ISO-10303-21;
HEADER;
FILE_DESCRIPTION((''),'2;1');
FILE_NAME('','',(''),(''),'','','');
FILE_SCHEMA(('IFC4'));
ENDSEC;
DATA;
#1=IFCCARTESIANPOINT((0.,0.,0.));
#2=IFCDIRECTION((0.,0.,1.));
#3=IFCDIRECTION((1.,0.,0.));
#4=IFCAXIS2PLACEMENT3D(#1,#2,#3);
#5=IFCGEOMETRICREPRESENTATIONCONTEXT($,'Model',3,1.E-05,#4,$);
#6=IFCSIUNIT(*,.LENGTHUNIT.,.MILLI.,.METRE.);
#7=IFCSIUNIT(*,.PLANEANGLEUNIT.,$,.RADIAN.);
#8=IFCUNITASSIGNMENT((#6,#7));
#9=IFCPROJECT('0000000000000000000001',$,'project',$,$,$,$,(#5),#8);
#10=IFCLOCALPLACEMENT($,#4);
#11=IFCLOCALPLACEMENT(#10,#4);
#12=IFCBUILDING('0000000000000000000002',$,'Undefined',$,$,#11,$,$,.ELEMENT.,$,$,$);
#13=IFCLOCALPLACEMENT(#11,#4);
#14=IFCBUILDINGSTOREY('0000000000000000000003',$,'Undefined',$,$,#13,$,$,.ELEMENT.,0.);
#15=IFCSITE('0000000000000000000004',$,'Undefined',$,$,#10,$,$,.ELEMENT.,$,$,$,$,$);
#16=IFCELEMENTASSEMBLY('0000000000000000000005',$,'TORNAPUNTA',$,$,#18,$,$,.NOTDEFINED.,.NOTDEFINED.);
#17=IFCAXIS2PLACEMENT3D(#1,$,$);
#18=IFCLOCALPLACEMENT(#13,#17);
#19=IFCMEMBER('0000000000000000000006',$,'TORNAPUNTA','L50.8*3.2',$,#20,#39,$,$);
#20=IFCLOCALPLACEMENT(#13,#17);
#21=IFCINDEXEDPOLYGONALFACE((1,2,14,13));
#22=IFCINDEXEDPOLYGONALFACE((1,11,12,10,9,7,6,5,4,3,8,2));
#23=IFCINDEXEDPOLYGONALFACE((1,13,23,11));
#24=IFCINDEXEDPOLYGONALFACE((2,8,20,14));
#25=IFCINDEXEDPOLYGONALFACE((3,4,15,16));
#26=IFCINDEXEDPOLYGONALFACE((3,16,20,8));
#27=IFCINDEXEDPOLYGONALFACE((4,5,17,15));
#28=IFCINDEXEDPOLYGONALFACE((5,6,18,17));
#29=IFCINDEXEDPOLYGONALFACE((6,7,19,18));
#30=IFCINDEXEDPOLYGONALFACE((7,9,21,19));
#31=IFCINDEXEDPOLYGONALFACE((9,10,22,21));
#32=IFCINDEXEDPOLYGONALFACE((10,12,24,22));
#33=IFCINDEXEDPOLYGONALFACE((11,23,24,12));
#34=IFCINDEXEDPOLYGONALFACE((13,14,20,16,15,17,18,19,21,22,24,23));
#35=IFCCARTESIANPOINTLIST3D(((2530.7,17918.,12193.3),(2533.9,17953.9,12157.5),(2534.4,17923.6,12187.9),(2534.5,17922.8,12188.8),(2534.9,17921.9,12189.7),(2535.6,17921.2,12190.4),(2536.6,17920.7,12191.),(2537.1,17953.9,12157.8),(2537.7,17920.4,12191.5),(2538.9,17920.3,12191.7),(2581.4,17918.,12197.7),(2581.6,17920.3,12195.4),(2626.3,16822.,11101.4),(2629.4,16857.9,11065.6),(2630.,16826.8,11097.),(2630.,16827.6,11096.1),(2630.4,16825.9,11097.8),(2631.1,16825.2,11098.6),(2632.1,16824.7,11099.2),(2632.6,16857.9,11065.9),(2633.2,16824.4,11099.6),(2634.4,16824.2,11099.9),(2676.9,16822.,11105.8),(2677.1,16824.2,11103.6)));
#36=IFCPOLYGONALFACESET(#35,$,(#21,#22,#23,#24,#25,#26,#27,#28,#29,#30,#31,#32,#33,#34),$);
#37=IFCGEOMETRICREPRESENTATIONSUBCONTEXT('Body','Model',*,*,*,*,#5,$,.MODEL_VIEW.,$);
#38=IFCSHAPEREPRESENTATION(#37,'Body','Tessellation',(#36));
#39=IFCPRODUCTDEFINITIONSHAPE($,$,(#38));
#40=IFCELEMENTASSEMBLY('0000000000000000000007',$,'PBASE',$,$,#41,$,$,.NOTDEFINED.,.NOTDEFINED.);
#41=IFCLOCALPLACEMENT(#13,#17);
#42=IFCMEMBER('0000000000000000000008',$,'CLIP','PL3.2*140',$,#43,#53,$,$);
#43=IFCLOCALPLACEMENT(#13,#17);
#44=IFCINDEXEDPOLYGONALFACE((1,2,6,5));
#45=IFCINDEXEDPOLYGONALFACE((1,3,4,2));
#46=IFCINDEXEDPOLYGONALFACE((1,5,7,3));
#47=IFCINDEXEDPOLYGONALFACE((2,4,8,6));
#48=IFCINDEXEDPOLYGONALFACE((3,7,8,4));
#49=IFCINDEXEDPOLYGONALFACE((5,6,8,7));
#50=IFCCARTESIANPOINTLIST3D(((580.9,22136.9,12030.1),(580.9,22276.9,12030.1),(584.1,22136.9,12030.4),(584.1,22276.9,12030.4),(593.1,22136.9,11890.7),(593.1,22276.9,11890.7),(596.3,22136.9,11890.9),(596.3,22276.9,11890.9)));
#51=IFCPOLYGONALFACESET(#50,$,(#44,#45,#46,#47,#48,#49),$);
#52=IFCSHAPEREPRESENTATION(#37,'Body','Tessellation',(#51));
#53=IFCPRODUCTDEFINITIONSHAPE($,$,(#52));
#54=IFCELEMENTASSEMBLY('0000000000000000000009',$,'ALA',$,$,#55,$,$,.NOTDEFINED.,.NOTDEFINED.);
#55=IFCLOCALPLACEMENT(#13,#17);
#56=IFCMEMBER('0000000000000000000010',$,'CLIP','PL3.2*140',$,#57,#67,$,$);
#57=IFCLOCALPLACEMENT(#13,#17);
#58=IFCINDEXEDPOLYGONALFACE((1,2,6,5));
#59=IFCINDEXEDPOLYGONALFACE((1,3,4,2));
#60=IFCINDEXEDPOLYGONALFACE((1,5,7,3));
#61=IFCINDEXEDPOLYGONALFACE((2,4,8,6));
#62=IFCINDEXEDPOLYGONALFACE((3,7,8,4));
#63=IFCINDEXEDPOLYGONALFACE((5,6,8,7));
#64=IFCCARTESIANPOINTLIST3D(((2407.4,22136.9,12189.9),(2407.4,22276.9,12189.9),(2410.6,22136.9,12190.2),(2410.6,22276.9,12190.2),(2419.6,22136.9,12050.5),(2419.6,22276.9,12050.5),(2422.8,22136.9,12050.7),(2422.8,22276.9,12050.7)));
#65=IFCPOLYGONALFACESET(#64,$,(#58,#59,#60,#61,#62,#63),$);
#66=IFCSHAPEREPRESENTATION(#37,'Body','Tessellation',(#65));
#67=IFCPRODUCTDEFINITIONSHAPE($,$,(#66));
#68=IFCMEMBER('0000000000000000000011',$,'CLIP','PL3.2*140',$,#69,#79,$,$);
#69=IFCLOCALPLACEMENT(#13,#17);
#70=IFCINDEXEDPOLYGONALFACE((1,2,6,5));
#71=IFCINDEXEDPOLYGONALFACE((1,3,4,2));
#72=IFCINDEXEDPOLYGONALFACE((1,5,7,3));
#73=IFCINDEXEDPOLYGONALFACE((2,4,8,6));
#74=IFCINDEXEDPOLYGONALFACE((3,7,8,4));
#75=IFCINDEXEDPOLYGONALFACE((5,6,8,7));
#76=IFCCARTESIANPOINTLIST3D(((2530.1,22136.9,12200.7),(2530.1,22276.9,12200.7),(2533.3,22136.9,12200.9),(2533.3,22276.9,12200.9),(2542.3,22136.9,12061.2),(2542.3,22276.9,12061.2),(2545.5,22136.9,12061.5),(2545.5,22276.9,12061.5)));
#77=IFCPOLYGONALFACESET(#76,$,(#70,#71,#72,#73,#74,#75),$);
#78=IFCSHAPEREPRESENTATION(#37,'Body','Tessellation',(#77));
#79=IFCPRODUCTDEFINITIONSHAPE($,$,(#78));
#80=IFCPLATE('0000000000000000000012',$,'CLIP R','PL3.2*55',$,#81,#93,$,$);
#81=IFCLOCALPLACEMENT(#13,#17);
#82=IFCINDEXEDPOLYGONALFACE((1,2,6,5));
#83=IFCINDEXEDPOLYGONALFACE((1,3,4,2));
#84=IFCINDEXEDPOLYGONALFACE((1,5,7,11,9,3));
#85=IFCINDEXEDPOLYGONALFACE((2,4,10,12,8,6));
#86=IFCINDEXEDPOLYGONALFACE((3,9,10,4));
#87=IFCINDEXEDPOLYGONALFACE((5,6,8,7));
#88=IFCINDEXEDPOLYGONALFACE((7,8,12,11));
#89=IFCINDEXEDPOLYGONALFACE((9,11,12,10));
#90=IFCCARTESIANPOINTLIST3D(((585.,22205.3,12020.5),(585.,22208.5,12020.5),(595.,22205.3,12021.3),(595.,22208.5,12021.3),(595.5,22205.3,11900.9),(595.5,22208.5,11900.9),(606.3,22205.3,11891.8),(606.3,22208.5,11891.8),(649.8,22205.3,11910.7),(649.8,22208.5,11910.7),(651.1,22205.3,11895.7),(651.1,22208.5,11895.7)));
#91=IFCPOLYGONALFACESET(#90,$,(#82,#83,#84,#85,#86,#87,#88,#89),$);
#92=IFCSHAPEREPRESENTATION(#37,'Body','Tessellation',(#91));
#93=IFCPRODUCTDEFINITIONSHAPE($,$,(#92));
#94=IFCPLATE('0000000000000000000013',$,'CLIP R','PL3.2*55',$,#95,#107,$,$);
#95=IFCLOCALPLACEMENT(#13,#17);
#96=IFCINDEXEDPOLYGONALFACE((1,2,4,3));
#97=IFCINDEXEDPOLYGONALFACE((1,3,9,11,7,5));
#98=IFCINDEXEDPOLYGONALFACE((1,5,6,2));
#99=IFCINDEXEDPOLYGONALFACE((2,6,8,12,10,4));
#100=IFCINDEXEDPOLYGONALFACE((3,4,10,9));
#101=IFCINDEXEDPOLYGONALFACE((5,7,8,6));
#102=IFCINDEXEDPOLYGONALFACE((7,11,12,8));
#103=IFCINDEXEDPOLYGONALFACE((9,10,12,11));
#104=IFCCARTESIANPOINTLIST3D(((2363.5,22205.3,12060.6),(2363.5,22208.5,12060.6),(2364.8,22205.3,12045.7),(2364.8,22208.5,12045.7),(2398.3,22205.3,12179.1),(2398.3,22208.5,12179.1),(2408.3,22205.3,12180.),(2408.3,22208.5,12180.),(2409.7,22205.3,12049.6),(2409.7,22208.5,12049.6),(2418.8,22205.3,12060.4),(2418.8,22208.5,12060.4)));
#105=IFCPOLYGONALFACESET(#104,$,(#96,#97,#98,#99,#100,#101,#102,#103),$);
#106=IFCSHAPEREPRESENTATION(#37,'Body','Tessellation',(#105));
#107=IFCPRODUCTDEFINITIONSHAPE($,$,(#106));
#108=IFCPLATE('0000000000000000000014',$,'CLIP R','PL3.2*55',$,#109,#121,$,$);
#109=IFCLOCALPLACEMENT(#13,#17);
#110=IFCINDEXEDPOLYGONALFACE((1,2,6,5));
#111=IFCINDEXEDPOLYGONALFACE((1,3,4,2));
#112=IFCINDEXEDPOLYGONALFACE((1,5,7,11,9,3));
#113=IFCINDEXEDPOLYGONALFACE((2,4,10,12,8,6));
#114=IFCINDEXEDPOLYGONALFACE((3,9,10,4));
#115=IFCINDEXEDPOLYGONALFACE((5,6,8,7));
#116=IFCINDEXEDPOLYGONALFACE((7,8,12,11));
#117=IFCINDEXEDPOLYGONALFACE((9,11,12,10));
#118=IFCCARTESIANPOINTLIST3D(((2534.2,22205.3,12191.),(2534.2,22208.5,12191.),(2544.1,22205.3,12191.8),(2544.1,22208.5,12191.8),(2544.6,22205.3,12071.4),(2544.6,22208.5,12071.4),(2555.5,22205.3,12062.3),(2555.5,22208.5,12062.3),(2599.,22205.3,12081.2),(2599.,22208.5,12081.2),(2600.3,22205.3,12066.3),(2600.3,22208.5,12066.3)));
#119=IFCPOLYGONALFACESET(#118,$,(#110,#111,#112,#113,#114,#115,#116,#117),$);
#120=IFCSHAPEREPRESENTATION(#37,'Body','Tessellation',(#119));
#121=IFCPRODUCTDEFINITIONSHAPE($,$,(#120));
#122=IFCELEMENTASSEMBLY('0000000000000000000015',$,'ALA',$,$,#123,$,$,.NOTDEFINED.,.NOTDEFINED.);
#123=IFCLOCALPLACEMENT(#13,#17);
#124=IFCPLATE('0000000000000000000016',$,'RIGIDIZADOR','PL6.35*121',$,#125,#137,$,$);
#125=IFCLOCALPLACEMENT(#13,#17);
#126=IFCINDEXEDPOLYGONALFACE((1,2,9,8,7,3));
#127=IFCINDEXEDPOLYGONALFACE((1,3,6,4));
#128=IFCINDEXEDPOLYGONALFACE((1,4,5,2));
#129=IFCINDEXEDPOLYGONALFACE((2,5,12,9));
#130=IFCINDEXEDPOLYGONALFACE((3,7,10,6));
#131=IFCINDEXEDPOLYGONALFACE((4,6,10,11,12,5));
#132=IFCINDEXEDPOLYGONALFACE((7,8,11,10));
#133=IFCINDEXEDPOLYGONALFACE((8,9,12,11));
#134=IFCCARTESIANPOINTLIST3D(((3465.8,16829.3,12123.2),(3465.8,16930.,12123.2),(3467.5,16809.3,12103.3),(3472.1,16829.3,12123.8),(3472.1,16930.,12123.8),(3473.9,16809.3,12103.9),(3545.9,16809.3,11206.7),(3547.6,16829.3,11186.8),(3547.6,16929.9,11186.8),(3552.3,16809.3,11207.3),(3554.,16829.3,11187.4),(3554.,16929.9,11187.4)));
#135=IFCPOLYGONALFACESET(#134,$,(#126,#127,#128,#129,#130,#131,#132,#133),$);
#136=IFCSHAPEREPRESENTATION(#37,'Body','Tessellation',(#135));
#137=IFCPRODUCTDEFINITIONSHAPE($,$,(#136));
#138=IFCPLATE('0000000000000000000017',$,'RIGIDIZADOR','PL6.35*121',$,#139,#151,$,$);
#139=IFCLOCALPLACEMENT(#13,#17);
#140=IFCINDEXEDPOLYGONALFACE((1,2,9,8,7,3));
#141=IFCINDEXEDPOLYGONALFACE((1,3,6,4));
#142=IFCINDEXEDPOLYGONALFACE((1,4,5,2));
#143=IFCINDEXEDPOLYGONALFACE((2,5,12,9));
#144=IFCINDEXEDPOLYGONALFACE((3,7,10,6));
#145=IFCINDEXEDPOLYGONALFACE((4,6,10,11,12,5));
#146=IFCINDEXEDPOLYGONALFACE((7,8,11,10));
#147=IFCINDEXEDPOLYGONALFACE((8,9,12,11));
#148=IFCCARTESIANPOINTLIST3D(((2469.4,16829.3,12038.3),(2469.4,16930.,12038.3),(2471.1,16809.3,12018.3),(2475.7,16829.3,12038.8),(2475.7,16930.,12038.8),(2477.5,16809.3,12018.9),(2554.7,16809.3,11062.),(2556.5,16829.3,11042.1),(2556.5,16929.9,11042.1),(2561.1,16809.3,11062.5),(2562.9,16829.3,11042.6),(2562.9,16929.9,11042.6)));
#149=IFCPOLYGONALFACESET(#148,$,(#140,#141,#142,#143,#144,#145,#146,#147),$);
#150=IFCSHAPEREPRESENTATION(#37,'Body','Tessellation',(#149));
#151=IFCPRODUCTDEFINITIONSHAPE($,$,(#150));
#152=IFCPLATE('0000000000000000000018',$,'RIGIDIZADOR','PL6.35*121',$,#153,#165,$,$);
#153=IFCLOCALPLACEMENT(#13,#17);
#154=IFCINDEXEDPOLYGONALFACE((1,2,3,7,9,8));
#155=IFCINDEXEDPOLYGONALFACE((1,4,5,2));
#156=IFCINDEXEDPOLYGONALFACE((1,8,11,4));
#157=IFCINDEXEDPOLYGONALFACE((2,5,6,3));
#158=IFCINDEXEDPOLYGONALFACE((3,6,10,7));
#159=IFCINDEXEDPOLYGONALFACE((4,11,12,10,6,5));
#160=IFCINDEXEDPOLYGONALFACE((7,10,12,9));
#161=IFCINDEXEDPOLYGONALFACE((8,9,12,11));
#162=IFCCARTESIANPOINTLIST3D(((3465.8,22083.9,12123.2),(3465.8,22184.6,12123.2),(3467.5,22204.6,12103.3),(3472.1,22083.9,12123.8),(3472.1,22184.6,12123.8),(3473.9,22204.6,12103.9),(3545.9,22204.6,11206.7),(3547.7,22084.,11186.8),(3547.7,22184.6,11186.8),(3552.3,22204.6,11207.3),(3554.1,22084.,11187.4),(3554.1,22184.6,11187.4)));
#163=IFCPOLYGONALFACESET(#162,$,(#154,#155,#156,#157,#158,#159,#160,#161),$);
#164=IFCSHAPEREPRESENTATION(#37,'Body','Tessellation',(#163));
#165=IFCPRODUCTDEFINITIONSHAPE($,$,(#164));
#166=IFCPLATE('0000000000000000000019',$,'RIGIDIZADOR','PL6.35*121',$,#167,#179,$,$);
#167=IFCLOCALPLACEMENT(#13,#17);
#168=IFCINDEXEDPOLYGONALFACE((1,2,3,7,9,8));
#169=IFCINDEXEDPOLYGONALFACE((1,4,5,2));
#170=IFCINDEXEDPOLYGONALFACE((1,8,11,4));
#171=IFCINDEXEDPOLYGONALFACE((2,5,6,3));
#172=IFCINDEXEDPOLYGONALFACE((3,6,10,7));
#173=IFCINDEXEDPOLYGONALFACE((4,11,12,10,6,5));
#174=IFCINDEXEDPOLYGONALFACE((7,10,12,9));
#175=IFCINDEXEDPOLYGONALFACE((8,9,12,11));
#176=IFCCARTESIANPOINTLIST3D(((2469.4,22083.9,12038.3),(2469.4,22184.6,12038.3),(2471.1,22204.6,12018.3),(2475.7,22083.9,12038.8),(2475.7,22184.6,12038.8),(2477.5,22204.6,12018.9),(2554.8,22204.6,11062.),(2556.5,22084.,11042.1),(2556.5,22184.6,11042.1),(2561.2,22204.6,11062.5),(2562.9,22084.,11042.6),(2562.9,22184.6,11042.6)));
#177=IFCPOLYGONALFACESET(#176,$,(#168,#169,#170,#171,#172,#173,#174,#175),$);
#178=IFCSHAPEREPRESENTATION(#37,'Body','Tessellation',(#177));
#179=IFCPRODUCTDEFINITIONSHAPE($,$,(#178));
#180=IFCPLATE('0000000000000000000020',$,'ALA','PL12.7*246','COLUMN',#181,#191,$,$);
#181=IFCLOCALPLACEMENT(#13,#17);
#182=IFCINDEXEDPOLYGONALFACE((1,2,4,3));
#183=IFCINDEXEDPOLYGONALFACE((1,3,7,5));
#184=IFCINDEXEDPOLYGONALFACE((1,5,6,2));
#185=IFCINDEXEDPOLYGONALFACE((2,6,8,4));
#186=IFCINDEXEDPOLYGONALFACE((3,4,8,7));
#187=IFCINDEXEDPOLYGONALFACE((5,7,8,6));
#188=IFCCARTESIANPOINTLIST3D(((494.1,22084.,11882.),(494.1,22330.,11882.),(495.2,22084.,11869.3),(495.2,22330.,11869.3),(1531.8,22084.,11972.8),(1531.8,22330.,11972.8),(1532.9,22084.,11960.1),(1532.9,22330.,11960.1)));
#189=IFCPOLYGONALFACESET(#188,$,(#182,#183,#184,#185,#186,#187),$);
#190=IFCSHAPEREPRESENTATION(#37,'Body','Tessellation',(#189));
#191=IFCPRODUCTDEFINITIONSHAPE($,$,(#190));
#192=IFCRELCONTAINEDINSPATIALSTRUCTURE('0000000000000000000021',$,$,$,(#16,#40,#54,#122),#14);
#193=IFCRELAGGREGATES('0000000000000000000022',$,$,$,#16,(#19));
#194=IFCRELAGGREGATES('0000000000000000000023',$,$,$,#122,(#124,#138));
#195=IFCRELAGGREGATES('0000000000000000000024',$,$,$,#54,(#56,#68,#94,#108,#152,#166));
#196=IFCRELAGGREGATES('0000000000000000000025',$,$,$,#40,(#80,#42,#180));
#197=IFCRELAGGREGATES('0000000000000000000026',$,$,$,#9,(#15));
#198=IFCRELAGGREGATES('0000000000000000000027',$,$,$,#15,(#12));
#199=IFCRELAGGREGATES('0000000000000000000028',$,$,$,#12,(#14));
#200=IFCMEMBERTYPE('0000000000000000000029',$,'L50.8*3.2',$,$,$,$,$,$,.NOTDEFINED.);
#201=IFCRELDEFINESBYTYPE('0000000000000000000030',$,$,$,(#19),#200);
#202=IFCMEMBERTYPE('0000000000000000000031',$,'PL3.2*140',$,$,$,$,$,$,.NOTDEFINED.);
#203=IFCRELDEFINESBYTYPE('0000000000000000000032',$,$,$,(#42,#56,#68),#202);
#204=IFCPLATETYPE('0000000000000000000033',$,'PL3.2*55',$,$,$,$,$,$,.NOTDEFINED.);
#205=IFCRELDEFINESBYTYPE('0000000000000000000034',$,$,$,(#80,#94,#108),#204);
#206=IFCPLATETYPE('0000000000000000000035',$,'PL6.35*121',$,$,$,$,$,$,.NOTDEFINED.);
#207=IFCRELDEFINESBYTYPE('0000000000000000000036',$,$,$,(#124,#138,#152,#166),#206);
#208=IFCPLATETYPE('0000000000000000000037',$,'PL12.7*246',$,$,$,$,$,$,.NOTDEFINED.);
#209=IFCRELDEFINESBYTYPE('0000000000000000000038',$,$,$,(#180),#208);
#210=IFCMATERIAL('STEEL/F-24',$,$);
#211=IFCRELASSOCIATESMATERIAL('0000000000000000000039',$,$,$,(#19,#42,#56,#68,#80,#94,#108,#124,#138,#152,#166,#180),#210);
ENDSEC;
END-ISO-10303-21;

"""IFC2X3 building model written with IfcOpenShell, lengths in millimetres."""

from ifc_helpers import new_model, si_unit, frame, origin_with_axes, origin_2d_with_axis, place, context, subcontext, project, spatial, polyline, rectangle, l_section, outline, extrude, material, type_object, element, aggregate, save


model = new_model("IFC2X3")

# Units and contexts
model_context = context("Model", 3, precision=1e-05, world=origin_with_axes())
body_context = subcontext(model_context, "Body", "Model", "MODEL_VIEW")
ifc_project = project(units=[si_unit("LENGTHUNIT", "METRE", prefix="MILLI"), si_unit("PLANEANGLEUNIT", "RADIAN")], contexts=[model_context])

# Site, building, storey
site_placement = place(None, origin_with_axes())
site = spatial("IfcSite", under=ifc_project, at=site_placement, Name="Undefined", CompositionType="ELEMENT")
building_placement = place(site_placement, origin_with_axes())
building = spatial("IfcBuilding", under=site, at=building_placement, Name="Undefined", CompositionType="ELEMENT")
storey_placement = place(building_placement, origin_with_axes())
storey = spatial("IfcBuildingStorey", under=building, at=storey_placement, Name="Undefined", CompositionType="ELEMENT", Elevation=0.0)

# Element assemblies, members
assembly_1_placement = place(storey_placement, origin_with_axes())
assembly_1 = element("IfcElementAssembly", 1, at=assembly_1_placement, inside=storey, Name="TORNAPUNTA", AssemblyPlace="NOTDEFINED", PredefinedType="NOTDEFINED")
ifc_material_1 = material(Name="STEEL/F-24")
member_type_1 = type_object("IfcMemberType", Name="L50.8*3.2", PredefinedType="NOTDEFINED")
member_1_placement = place(assembly_1_placement, frame((2557.6, 17935.9, 12177.6), z_axis=(0.061628, 0.707107, -0.704416), x_axis=(0.061628, -0.707107, -0.704416)))
member_1 = element("IfcMember", 2, at=member_1_placement, type_object=member_type_1, material=ifc_material_1, Name="TORNAPUNTA", Description="L50.8*3.2", context=body_context, shape_type="SweptSolid", body=[
    extrude(l_section(Depth=50.8, Width=50.8, Thickness=3.2, FilletRadius=4.8, at=origin_2d_with_axis()), frame((1550.0, 0.0, 0.0), z_axis=(-1.0, 0.0, 0.0), x_axis=(0.0, -1.0, 0.0)), (0.0, 0.0, 1.0), 1550.0),
])
aggregate(assembly_1, [member_1])
assembly_2_placement = place(storey_placement, origin_with_axes())
assembly_2 = element("IfcElementAssembly", 3, at=assembly_2_placement, inside=storey, Name="PBASE", AssemblyPlace="NOTDEFINED", PredefinedType="NOTDEFINED")
member_type_2 = type_object("IfcMemberType", Name="PL3.2*140", PredefinedType="NOTDEFINED")
member_2_placement = place(assembly_2_placement, frame((582.5, 22206.9, 12030.3), z_axis=(0.0, -1.0, 0.0), x_axis=(0.087155, 0.0, -0.996195)))
member_2 = element("IfcMember", 4, at=member_2_placement, type_object=member_type_2, material=ifc_material_1, Name="CLIP", Description="PL3.2*140", context=body_context, shape_type="SweptSolid", body=[
    extrude(rectangle(XDim=3.2, YDim=140.0, at=origin_2d_with_axis()), frame((140.0, 0.0, 0.0), z_axis=(-1.0, 0.0, 0.0), x_axis=(0.0, -1.0, 0.0)), (0.0, 0.0, 1.0), 140.0),
])

# Element assembly, members
assembly_3_placement = place(storey_placement, origin_with_axes())
assembly_3 = element("IfcElementAssembly", 5, at=assembly_3_placement, inside=storey, Name="ALA", AssemblyPlace="NOTDEFINED", PredefinedType="NOTDEFINED")
member_3_placement = place(assembly_3_placement, frame((2409.0, 22206.9, 12190.1), z_axis=(0.0, -1.0, 0.0), x_axis=(0.087155, 0.0, -0.996195)))
member_3 = element("IfcMember", 6, at=member_3_placement, type_object=member_type_2, material=ifc_material_1, Name="CLIP", Description="PL3.2*140", context=body_context, shape_type="SweptSolid", body=[
    extrude(rectangle(XDim=3.2, YDim=140.0, at=origin_2d_with_axis()), frame((140.0, 0.0, 0.0), z_axis=(-1.0, 0.0, 0.0), x_axis=(0.0, -1.0, 0.0)), (0.0, 0.0, 1.0), 140.0),
])
member_4_placement = place(assembly_3_placement, frame((2531.7, 22206.9, 12200.8), z_axis=(0.0, -1.0, 0.0), x_axis=(0.087155, 0.0, -0.996195)))
member_4 = element("IfcMember", 7, at=member_4_placement, type_object=member_type_2, material=ifc_material_1, Name="CLIP", Description="PL3.2*140", context=body_context, shape_type="SweptSolid", body=[
    extrude(rectangle(XDim=3.2, YDim=140.0, at=origin_2d_with_axis()), frame((140.0, 0.0, 0.0), z_axis=(-1.0, 0.0, 0.0), x_axis=(0.0, -1.0, 0.0)), (0.0, 0.0, 1.0), 140.0),
])

# Plates
plate_type_1 = type_object("IfcPlateType", Name="PL3.2*55", PredefinedType="NOTDEFINED")
plate_1_placement = place(assembly_2_placement, frame((585.0, 22206.9, 12020.5), z_axis=(0.0, 1.0, 0.0), x_axis=(0.996195, 0.0, 0.087155)))
plate_1 = element("IfcPlate", 8, at=plate_1_placement, type_object=plate_type_1, material=ifc_material_1, Name="CLIP R", Description="PL3.2*55", context=body_context, shape_type="SweptSolid", body=[
    extrude(outline(polyline([(0.0, 0.0), (10.0, 0.0), (55.0, 115.0), (55.0, 130.0), (10.0, 130.0), (0.0, 120.0), (0.0, 0.0)])), frame((0.0, 0.0, -1.6), z_axis=(0.0, 0.0, 1.0), x_axis=(1.0, 0.0, 0.0)), (0.0, 0.0, 1.0), 3.2),
])
plate_2_placement = place(assembly_3_placement, frame((2408.3, 22206.9, 12180.0), z_axis=(0.0, -1.0, 0.0), x_axis=(-0.996195, 0.0, -0.087155)))
plate_2 = element("IfcPlate", 9, at=plate_2_placement, type_object=plate_type_1, material=ifc_material_1, Name="CLIP R", Description="PL3.2*55", context=body_context, shape_type="SweptSolid", body=[
    extrude(outline(polyline([(0.0, 0.0), (10.0, 0.0), (55.0, 115.0), (55.0, 130.0), (10.0, 130.0), (0.0, 120.0), (0.0, 0.0)])), frame((0.0, 0.0, -1.6), z_axis=(0.0, 0.0, 1.0), x_axis=(1.0, 0.0, 0.0)), (0.0, 0.0, 1.0), 3.2),
])
plate_3_placement = place(assembly_3_placement, frame((2534.2, 22206.9, 12191.0), z_axis=(0.0, 1.0, 0.0), x_axis=(0.996195, 0.0, 0.087155)))
plate_3 = element("IfcPlate", 10, at=plate_3_placement, type_object=plate_type_1, material=ifc_material_1, Name="CLIP R", Description="PL3.2*55", context=body_context, shape_type="SweptSolid", body=[
    extrude(outline(polyline([(0.0, 0.0), (10.0, 0.0), (55.0, 115.0), (55.0, 130.0), (10.0, 130.0), (0.0, 120.0), (0.0, 0.0)])), frame((0.0, 0.0, -1.6), z_axis=(0.0, 0.0, 1.0), x_axis=(1.0, 0.0, 0.0)), (0.0, 0.0, 1.0), 3.2),
])

# Element assembly, plates
assembly_4_placement = place(storey_placement, origin_with_axes())
assembly_4 = element("IfcElementAssembly", 11, at=assembly_4_placement, inside=storey, Name="ALA", AssemblyPlace="NOTDEFINED", PredefinedType="NOTDEFINED")
plate_type_2 = type_object("IfcPlateType", Name="PL6.35*121", PredefinedType="NOTDEFINED")
plate_4_placement = place(assembly_4_placement, frame((3468.9, 16809.3, 12123.5), z_axis=(-0.996198, 0.0, -0.087123), x_axis=(0.0, 1.0, 0.0)))
plate_4 = element("IfcPlate", 12, at=plate_4_placement, type_object=plate_type_2, material=ifc_material_1, Name="RIGIDIZADOR", Description="PL6.35*121", context=body_context, shape_type="SweptSolid", body=[
    extrude(outline(polyline([(0.0, 20.0), (20.0, 0.0), (120.6, 0.0), (120.6, 940.0), (20.0, 940.0), (0.0, 920.0), (0.0, 20.0)])), frame((0.0, 0.0, -3.2), z_axis=(0.0, 0.0, 1.0), x_axis=(1.0, 0.0, 0.0)), (0.0, 0.0, 1.0), 6.4),
])
plate_5_placement = place(assembly_4_placement, frame((2472.6, 16809.3, 12038.5), z_axis=(-0.996197, 0.0, -0.087125), x_axis=(0.0, 1.0, 0.0)))
plate_5 = element("IfcPlate", 13, at=plate_5_placement, type_object=plate_type_2, material=ifc_material_1, Name="RIGIDIZADOR", Description="PL6.35*121", context=body_context, shape_type="SweptSolid", body=[
    extrude(outline(polyline([(0.0, 20.0), (20.0, 0.0), (120.6, 0.0), (120.6, 1000.0), (20.0, 1000.0), (0.0, 980.0), (0.0, 20.0)])), frame((0.0, 0.0, -3.2), z_axis=(0.0, 0.0, 1.0), x_axis=(1.0, 0.0, 0.0)), (0.0, 0.0, 1.0), 6.4),
])
aggregate(assembly_4, [plate_4, plate_5])

# Plates
plate_6_placement = place(assembly_3_placement, frame((3468.9, 22204.6, 12123.5), z_axis=(0.996195, 0.0, 0.087155), x_axis=(0.0, -1.0, 0.0)))
plate_6 = element("IfcPlate", 14, at=plate_6_placement, type_object=plate_type_2, material=ifc_material_1, Name="RIGIDIZADOR", Description="PL6.35*121", context=body_context, shape_type="SweptSolid", body=[
    extrude(outline(polyline([(0.0, 20.0), (20.0, 0.0), (120.6, 0.0), (120.6, 940.0), (20.0, 940.0), (0.0, 920.0), (0.0, 20.0)])), frame((0.0, 0.0, -3.2), z_axis=(0.0, 0.0, 1.0), x_axis=(1.0, 0.0, 0.0)), (0.0, 0.0, 1.0), 6.4),
])
plate_7_placement = place(assembly_3_placement, frame((2472.6, 22204.6, 12038.5), z_axis=(0.996195, 0.0, 0.087155), x_axis=(0.0, -1.0, 0.0)))
plate_7 = element("IfcPlate", 15, at=plate_7_placement, type_object=plate_type_2, material=ifc_material_1, Name="RIGIDIZADOR", Description="PL6.35*121", context=body_context, shape_type="SweptSolid", body=[
    extrude(outline(polyline([(0.0, 20.0), (20.0, 0.0), (120.6, 0.0), (120.6, 1000.0), (20.0, 1000.0), (0.0, 980.0), (0.0, 20.0)])), frame((0.0, 0.0, -3.2), z_axis=(0.0, 0.0, 1.0), x_axis=(1.0, 0.0, 0.0)), (0.0, 0.0, 1.0), 6.4),
])
aggregate(assembly_3, [member_3, member_4, plate_2, plate_3, plate_6, plate_7])
plate_type_3 = type_object("IfcPlateType", Name="PL12.7*246", PredefinedType="NOTDEFINED")
plate_8_placement = place(assembly_2_placement, frame((1532.3, 22207.0, 11966.5), z_axis=(-0.087153, 0.0, 0.996195), x_axis=(-0.996195, 0.0, -0.087153)))
plate_8 = element("IfcPlate", 16, at=plate_8_placement, type_object=plate_type_3, material=ifc_material_1, Name="ALA", Description="PL12.7*246", ObjectType="COLUMN", context=body_context, shape_type="SweptSolid", body=[
    extrude(outline(polyline([(0.0, -123.0), (0.0, 123.0), (1041.7, 123.0), (1041.7, -123.0), (0.0, -123.0)])), frame((0.0, 0.0, -6.3), z_axis=(0.0, 0.0, 1.0), x_axis=(1.0, 0.0, 0.0)), (0.0, 0.0, 1.0), 12.7),
])

aggregate(assembly_2, [plate_1, member_2, plate_8])

save(model, "model.ifc")
